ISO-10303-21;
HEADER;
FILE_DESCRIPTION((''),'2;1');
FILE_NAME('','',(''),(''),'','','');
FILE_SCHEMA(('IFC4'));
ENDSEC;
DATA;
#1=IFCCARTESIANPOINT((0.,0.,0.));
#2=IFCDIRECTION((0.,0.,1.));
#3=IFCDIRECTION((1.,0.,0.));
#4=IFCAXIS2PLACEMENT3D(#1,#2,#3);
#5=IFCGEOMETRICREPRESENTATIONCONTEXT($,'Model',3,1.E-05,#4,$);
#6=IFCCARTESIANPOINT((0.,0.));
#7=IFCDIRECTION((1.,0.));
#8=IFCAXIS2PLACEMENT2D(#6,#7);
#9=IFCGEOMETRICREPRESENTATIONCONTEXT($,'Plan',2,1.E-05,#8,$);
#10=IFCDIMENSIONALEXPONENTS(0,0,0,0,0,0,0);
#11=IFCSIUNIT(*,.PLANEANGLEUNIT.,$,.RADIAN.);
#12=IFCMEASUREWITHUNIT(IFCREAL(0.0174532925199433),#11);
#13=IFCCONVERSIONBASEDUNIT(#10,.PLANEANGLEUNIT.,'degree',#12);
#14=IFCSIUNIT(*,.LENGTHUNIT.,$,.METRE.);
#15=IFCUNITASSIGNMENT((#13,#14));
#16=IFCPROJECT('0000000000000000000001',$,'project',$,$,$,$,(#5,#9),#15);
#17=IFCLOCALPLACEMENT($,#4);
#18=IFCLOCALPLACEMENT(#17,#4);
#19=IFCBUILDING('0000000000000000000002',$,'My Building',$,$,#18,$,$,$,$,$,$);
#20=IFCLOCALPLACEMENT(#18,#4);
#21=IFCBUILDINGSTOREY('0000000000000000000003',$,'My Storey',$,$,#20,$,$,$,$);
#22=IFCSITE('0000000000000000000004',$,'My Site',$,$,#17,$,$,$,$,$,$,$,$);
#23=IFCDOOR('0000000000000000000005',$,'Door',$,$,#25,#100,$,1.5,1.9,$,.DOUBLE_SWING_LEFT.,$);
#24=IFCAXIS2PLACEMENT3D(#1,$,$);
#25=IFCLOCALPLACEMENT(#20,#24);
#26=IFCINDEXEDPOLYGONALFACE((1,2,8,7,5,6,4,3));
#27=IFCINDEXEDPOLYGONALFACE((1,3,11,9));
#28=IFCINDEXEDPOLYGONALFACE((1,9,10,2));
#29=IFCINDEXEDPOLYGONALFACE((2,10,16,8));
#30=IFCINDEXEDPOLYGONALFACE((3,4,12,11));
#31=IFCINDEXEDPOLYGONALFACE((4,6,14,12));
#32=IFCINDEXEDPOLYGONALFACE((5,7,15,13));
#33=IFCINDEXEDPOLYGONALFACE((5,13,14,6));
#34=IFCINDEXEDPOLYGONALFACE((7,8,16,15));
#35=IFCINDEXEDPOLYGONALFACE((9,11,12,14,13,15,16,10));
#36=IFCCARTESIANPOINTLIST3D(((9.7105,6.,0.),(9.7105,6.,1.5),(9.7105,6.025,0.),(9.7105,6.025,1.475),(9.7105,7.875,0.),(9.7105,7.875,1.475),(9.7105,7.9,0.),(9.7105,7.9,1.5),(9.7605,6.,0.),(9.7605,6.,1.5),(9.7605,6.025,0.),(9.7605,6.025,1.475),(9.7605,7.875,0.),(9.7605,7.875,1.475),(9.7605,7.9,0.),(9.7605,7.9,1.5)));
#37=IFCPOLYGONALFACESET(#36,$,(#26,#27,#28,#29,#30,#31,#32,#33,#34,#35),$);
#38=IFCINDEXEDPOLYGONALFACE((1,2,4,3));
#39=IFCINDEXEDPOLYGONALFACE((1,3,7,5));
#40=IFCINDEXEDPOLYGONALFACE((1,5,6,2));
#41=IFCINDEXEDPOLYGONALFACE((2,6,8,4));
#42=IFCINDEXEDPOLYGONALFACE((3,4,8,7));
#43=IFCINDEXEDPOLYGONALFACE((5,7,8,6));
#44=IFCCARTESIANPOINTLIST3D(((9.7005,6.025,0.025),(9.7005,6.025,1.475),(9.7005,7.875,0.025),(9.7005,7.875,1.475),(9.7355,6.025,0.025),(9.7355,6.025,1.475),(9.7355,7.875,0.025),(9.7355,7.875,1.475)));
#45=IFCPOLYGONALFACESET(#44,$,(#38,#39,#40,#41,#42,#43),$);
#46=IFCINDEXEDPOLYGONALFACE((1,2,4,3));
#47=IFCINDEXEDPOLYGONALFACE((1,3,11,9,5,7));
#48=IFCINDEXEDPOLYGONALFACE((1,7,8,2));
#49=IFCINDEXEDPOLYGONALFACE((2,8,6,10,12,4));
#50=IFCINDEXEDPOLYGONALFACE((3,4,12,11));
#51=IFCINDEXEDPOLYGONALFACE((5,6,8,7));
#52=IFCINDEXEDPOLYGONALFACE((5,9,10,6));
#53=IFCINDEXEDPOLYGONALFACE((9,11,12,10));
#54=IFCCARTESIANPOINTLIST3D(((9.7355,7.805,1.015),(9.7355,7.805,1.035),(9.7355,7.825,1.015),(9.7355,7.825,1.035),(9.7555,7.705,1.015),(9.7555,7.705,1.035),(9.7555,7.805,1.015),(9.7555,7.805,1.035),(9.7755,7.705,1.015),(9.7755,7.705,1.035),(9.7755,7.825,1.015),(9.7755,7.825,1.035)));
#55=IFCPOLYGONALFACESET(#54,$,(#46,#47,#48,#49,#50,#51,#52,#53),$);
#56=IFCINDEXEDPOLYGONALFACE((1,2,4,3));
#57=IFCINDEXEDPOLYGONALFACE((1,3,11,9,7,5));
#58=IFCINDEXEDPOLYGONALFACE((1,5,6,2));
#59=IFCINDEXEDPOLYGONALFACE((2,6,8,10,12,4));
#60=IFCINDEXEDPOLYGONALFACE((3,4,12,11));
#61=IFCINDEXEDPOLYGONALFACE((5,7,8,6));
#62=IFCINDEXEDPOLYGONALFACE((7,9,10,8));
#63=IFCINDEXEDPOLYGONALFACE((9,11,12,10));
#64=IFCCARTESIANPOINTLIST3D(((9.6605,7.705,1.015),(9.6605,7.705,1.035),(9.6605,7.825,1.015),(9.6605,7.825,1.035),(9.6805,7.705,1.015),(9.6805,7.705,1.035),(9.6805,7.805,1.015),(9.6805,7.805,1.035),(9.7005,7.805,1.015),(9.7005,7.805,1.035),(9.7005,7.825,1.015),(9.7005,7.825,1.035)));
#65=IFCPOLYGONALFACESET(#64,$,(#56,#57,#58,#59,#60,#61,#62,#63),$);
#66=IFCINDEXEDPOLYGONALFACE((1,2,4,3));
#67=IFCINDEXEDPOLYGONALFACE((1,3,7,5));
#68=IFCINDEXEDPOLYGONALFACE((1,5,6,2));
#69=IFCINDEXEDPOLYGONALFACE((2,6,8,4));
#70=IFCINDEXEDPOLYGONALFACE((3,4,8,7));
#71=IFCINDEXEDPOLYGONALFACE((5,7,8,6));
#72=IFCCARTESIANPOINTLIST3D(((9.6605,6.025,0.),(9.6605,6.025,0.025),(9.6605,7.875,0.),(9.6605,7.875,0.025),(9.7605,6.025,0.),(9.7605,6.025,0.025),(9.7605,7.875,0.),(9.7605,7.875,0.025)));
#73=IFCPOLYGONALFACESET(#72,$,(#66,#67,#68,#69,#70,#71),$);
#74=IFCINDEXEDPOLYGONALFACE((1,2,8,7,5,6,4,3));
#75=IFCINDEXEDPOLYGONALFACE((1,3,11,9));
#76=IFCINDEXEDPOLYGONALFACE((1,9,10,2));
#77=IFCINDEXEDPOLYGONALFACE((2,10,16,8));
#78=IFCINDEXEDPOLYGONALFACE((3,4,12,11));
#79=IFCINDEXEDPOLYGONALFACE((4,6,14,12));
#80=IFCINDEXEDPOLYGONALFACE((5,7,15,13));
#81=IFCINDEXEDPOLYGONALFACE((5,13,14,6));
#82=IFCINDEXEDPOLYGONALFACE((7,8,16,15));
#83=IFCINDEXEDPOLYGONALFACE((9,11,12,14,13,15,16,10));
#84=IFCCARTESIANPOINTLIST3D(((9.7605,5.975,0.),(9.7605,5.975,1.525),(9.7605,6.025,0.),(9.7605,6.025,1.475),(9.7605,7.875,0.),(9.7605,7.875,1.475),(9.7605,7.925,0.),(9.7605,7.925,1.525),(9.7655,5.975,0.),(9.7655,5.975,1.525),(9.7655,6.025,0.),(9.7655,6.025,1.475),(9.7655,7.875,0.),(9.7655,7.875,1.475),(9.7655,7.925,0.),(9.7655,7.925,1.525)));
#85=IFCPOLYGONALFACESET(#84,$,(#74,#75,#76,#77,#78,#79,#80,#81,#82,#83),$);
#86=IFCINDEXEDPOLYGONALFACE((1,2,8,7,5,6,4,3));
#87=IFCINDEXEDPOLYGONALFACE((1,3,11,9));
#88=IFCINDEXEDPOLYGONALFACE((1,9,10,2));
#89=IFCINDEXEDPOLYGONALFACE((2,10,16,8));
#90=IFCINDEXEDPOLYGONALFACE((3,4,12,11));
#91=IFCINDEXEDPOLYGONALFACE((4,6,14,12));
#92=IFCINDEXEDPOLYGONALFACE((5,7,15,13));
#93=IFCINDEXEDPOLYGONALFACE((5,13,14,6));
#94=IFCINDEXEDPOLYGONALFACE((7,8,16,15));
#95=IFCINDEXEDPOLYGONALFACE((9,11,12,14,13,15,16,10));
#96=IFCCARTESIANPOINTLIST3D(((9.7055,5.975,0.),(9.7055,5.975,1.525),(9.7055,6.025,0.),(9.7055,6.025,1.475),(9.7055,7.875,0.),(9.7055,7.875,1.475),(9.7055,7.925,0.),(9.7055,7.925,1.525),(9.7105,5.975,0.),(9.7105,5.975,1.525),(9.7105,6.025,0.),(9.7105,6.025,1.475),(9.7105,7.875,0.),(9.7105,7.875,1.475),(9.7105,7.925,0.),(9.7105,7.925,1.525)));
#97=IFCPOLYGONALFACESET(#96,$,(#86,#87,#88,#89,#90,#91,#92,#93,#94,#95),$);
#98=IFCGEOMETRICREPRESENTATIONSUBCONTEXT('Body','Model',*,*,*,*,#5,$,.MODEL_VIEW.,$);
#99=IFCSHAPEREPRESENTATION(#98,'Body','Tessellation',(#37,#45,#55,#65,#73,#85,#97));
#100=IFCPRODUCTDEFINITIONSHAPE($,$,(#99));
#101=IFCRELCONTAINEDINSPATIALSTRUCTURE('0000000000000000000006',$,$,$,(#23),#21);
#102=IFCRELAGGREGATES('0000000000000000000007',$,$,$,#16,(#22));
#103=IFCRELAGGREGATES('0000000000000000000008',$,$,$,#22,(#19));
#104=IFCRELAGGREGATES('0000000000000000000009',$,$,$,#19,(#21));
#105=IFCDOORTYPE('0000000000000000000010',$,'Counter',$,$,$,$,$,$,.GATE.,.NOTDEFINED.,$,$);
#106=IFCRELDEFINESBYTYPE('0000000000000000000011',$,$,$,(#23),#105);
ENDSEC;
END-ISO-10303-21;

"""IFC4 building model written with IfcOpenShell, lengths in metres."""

from ifc_helpers import new_model, entity, si_unit, converted_unit, frame, origin_with_axes, origin_2d_with_axis, place, context, subcontext, project, spatial, line, indexed_curve, outline, extrude, shape, source, transform, mapped, type_object, type_shapes, element, save


model = new_model("IFC4")

# Units and contexts
model_context = context("Model", 3, precision=1e-05, world=origin_with_axes())
plan_context = context("Plan", 2, precision=1e-05, world=origin_2d_with_axis())
body_context_1 = subcontext(model_context, "Body", "Model", "MODEL_VIEW")
body_context_2 = subcontext(plan_context, "Body", "Plan", "PLAN_VIEW")
ifc_project = project(units=[converted_unit("PLANEANGLEUNIT", "degree", entity("IfcReal", 0.0174532925199433), si_unit("PLANEANGLEUNIT", "RADIAN"), dimensions=[0, 0, 0, 0, 0, 0, 0]), si_unit("LENGTHUNIT", "METRE")], contexts=[model_context, plan_context])

# Site, building, storey
site_placement = place(None, origin_with_axes())
site = spatial("IfcSite", under=ifc_project, at=site_placement, Name="My Site")
building_placement = place(site_placement, origin_with_axes())
building = spatial("IfcBuilding", under=site, at=building_placement, Name="My Building")
storey_placement = place(building_placement, origin_with_axes())
storey = spatial("IfcBuildingStorey", under=building, at=storey_placement, Name="My Storey")

# Door
door_type = type_object("IfcDoorType", Name="Counter", OperationType="NOTDEFINED", PredefinedType="GATE")
shared_shape_1 = source(origin_with_axes(), body_context_1, "Body", "SweptSolid", [
    extrude(outline(indexed_curve([(0.0, 0.0), (0.0, 1.5), (1.9, 1.5), (1.9, 0.0), (1.875, 0.0), (1.875, 1.475), (0.025, 1.475), (0.025, 0.0)], segments=[line(1, 2, 3, 4, 5, 6, 7, 8, 1)])), frame((0.0, 0.0, 0.0), z_axis=(0.0, -1.0, 0.0), x_axis=(1.0, 0.0, 0.0)), (0.0, 0.0, -1.0), 0.05),
    extrude(outline(indexed_curve([(0.0, 0.0), (1.85, 0.0), (1.85, 0.035), (0.0, 0.035)], segments=[line(1, 2, 3, 4, 1)])), frame((0.025, 0.025, 0.025), z_axis=(0.0, 0.0, 1.0), x_axis=(1.0, 0.0, 0.0)), (0.0, 0.0, 1.0), 1.45),
    extrude(outline(indexed_curve([(0.0, 0.0), (0.0, -0.04), (-0.12, -0.04), (-0.12, -0.02), (-0.02, -0.02), (-0.02, 0.0)], segments=[line(1, 2, 3, 4, 5, 6, 1)])), frame((1.825, 0.025, 1.015), z_axis=(0.0, 0.0, 1.0), x_axis=(1.0, 0.0, 0.0)), (0.0, 0.0, 1.0), 0.02),
    extrude(outline(indexed_curve([(0.0, 0.0), (0.0, 0.04), (-0.12, 0.04), (-0.12, 0.02), (-0.02, 0.02), (-0.02, 0.0)], segments=[line(1, 2, 3, 4, 5, 6, 1)])), frame((1.825, 0.06, 1.015), z_axis=(0.0, 0.0, 1.0), x_axis=(1.0, 0.0, 0.0)), (0.0, 0.0, 1.0), 0.02),
    extrude(outline(indexed_curve([(0.0, 0.0), (1.85, 0.0), (1.85, 0.1), (0.0, 0.1)], segments=[line(1, 2, 3, 4, 1)])), frame((0.025, 0.0, 0.0), z_axis=(0.0, 0.0, 1.0), x_axis=(1.0, 0.0, 0.0)), (0.0, 0.0, 1.0), 0.025),
    extrude(outline(indexed_curve([(0.0, 0.0), (0.0, 1.525), (1.95, 1.525), (1.95, 0.0), (1.9, 0.0), (1.9, 1.475), (0.05, 1.475), (0.05, 0.0)], segments=[line(1, 2, 3, 4, 5, 6, 7, 8, 1)])), frame((-0.025, -0.005, 0.0), z_axis=(0.0, -1.0, 0.0), x_axis=(1.0, 0.0, 0.0)), (0.0, 0.0, -1.0), 0.005),
    extrude(outline(indexed_curve([(0.0, 0.0), (0.0, 1.525), (1.95, 1.525), (1.95, 0.0), (1.9, 0.0), (1.9, 1.475), (0.05, 1.475), (0.05, 0.0)], segments=[line(1, 2, 3, 4, 5, 6, 7, 8, 1)])), frame((-0.025, 0.05, 0.0), z_axis=(0.0, -1.0, 0.0), x_axis=(1.0, 0.0, 0.0)), (0.0, 0.0, -1.0), 0.005),
])
shared_shape_2 = source(origin_with_axes(), body_context_2, "Body", "Curve2D", [
    entity("IfcIndexedPolyCurve", entity("IfcCartesianPointList2D", [[0.0, 0.0], [0.025, 0.0], [0.025, 0.05], [0.0, 0.05]]), [entity("IfcLineIndex", [1, 2, 3, 4, 1])]),
    entity("IfcIndexedPolyCurve", entity("IfcCartesianPointList2D", [[1.9, 0.0], [1.875, 0.0], [1.875, 0.05], [1.9, 0.05]]), [entity("IfcLineIndex", [1, 2, 3, 4, 1])]),
    entity("IfcIndexedPolyCurve", entity("IfcCartesianPointList2D", [[0.025, 0.05], [0.025, -1.8], [0.06, -1.8]])),
    entity("IfcTrimmedCurve", entity("IfcEllipse", entity("IfcAxis2Placement2D", entity("IfcCartesianPoint", [0.06, 0.05]), entity("IfcDirection", [1.0, 0.0])), 1.815, 1.85), [entity("IfcCartesianPoint", [0.06, -1.8])], [entity("IfcCartesianPoint", [0.06, 1.9])], True, "CARTESIAN"),
    entity("IfcIndexedPolyCurve", entity("IfcCartesianPointList2D", [[0.025, 0.05], [0.06, 0.05], [0.06, 1.9], [0.025, 1.9]]), [entity("IfcLineIndex", [1, 2, 3, 4, 1])]),
])
type_shapes(door_type, [shared_shape_1, shared_shape_2])
door_placement = place(storey_placement, frame((9.7605, 6.0, 0.0), z_axis=(0.0, 0.0, 1.0), x_axis=(0.0, 1.0, 0.0)))
element("IfcDoor", 1, at=door_placement, inside=storey, type_object=door_type, Name="Door", OperationType="DOUBLE_SWING_LEFT", OverallHeight=1.5, OverallWidth=1.9, shapes=[
    shape(body_context_1, "Body", "MappedRepresentation", [mapped(shared_shape_1, transform((0.0, 0.0, 0.0), x_axis=(1.0, 0.0, 0.0), y_axis=(0.0, 1.0, 0.0), z_axis=(0.0, 0.0, 1.0), scale=1.0))]),
    shape(body_context_2, "Body", "MappedRepresentation", [mapped(shared_shape_2, transform((0.0, 0.0, 0.0), x_axis=(1.0, 0.0, 0.0), y_axis=(0.0, 1.0, 0.0), z_axis=(0.0, 0.0, 1.0), scale=1.0))]),
])

save(model, "model.ifc")
